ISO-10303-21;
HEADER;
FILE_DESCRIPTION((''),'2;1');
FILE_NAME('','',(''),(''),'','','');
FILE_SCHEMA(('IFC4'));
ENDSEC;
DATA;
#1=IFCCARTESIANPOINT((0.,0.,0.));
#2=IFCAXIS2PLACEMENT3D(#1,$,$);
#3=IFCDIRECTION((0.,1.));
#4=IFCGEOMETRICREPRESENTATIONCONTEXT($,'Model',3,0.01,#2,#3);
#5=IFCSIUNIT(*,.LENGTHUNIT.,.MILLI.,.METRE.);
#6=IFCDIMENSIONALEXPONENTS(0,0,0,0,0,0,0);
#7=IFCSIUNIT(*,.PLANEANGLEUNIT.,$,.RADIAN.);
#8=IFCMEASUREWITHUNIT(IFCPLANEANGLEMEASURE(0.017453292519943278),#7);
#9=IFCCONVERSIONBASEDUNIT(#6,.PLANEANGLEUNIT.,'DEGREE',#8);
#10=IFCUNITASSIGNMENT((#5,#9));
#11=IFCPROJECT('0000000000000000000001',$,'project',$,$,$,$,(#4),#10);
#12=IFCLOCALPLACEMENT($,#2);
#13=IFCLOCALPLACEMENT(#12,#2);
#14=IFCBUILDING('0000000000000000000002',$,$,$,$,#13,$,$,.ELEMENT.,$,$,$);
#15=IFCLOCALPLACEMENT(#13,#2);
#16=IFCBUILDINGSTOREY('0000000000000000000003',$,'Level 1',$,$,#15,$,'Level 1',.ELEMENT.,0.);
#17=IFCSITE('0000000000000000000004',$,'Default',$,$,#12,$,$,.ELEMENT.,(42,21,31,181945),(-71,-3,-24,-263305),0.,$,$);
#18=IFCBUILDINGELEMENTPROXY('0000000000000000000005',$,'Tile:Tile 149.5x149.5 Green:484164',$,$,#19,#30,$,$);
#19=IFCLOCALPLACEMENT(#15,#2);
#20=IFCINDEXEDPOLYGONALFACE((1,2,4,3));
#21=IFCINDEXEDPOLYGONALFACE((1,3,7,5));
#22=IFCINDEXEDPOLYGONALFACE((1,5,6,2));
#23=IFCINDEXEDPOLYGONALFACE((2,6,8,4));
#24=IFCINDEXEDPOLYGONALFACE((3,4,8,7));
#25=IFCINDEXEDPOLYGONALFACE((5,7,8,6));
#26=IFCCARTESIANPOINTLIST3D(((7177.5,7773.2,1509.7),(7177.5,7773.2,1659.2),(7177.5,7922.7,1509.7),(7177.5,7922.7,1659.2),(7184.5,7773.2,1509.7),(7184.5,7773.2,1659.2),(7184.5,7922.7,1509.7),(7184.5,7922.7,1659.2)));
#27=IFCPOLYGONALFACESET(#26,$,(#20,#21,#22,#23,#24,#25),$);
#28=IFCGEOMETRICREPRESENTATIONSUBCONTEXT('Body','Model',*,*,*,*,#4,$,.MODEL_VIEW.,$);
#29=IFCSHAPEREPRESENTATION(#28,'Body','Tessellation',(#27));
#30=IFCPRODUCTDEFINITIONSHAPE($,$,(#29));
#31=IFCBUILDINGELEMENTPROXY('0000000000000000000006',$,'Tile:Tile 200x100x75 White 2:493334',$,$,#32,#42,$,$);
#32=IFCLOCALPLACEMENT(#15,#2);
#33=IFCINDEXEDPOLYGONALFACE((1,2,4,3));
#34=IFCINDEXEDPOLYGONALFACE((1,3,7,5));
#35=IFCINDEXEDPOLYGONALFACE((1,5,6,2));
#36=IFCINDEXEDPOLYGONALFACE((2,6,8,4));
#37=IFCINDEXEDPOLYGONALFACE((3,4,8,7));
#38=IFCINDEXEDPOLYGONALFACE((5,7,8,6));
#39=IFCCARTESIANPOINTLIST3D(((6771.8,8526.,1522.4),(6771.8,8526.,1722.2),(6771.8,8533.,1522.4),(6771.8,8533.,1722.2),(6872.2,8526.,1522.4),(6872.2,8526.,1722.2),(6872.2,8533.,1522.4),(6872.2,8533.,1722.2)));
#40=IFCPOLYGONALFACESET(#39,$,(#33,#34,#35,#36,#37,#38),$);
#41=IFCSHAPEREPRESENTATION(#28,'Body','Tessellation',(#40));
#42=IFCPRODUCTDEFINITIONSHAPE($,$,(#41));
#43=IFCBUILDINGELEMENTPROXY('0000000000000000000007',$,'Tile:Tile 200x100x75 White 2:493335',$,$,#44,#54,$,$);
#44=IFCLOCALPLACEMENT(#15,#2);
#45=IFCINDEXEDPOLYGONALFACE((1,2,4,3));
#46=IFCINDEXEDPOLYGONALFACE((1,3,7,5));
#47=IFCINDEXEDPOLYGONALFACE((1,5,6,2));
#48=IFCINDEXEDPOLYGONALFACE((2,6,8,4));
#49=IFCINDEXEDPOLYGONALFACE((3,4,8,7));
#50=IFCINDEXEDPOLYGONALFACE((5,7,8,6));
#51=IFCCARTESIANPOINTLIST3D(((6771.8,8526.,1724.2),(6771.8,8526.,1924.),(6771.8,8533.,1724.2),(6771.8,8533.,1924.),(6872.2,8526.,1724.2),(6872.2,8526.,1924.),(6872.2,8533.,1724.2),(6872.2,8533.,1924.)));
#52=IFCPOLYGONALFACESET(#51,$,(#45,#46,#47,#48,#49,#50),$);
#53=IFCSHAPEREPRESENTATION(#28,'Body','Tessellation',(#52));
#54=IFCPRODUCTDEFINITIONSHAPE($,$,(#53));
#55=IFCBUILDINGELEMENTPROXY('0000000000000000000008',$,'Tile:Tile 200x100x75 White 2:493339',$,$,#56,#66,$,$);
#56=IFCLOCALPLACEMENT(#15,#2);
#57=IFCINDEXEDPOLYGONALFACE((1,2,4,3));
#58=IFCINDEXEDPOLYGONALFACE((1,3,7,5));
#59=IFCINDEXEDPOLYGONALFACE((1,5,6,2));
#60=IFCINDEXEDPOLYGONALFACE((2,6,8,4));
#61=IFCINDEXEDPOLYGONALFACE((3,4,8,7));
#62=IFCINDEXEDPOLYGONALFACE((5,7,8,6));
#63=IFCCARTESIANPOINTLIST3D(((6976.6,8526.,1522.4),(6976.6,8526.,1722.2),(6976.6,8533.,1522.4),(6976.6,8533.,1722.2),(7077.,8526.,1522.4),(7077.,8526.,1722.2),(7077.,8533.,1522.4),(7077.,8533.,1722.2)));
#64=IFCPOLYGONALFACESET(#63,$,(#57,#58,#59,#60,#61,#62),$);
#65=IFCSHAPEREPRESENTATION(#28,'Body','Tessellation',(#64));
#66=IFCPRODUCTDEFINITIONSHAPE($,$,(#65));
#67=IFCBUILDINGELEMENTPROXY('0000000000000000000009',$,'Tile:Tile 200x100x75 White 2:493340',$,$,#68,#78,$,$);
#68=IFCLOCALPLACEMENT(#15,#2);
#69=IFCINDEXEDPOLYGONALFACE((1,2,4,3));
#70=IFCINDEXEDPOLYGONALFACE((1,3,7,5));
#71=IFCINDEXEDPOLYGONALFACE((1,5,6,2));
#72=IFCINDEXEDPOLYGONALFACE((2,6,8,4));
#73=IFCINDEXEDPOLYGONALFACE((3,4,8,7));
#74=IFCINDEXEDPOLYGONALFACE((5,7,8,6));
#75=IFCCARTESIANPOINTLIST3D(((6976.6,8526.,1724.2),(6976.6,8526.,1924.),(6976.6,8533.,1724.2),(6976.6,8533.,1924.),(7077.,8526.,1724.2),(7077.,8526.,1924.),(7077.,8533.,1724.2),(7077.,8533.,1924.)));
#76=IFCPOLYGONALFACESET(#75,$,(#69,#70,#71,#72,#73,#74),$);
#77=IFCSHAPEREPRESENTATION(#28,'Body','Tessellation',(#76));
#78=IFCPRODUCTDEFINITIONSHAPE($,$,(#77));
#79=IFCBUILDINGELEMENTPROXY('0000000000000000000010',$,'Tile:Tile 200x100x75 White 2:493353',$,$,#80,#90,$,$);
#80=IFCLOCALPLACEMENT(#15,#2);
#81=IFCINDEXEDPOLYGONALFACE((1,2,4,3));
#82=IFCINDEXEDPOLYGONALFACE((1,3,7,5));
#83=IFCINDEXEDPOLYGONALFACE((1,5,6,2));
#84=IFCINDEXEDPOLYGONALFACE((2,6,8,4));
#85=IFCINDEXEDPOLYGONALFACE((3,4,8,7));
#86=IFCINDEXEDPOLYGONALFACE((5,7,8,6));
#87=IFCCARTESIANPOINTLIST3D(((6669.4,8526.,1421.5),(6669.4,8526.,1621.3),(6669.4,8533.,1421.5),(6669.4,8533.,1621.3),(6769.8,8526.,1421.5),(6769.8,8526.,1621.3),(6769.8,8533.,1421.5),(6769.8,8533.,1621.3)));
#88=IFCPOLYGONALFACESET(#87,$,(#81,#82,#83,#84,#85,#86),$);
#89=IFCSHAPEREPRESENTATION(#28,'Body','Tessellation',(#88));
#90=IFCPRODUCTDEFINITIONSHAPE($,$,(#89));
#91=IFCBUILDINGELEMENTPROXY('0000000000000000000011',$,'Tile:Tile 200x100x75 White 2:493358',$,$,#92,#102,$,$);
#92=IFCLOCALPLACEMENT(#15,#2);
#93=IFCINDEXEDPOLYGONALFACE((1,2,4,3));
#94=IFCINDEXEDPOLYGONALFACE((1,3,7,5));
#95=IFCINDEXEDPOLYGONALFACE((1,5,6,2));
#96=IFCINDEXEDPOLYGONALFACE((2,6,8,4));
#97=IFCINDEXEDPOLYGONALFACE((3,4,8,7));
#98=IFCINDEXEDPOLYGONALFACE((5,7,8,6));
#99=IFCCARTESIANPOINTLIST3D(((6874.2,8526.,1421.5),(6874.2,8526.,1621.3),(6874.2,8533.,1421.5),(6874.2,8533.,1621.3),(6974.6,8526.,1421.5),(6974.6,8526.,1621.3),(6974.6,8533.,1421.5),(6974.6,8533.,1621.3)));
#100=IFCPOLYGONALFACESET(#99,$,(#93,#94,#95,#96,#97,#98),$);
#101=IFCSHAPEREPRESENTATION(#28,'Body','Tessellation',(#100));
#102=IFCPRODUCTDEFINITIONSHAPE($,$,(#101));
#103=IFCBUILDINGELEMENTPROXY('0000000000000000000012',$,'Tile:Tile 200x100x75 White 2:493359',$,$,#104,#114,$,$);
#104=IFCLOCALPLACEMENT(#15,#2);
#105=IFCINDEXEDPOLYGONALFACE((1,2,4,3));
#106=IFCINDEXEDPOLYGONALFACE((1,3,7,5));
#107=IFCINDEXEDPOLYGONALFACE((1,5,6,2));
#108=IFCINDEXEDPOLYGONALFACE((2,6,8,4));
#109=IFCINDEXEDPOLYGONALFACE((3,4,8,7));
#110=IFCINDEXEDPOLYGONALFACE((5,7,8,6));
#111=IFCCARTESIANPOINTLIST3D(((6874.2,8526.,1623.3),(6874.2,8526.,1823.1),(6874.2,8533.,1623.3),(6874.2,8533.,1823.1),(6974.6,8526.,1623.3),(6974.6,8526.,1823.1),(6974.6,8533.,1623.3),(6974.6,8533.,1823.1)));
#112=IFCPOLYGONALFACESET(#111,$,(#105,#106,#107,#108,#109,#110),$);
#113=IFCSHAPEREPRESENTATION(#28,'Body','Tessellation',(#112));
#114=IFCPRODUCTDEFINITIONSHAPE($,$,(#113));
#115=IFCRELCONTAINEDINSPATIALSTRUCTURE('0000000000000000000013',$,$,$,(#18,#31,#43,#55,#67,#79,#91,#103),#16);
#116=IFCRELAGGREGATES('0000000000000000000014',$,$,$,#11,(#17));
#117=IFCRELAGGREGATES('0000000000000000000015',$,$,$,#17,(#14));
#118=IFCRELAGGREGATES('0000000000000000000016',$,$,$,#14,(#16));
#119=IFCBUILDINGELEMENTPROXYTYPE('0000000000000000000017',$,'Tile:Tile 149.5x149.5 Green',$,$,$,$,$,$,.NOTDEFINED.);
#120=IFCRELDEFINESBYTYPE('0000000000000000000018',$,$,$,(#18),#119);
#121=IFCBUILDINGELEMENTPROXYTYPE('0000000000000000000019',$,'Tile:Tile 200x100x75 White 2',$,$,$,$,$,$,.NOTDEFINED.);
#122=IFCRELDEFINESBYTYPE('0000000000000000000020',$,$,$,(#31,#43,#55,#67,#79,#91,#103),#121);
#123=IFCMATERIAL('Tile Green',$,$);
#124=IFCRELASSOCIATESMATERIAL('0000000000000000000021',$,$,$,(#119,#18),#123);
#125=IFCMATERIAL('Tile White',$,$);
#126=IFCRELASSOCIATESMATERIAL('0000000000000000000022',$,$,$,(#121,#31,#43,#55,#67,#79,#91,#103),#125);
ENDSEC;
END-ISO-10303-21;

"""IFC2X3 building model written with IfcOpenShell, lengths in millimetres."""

from ifc_helpers import new_model, entity, si_unit, converted_unit, direction, frame, frame_2d, origin, origin_2d_with_axis, place, context, subcontext, project, spatial, rectangle, extrude, source, transform, mapped, material, type_object, type_shapes, element, save


model = new_model("IFC2X3")

# Units and contexts
model_context = context("Model", 3, precision=0.01, world=origin(), true_north=direction((0.0, 1.0)))
body_context = subcontext(model_context, "Body", "Model", "MODEL_VIEW")
ifc_project = project(units=[si_unit("LENGTHUNIT", "METRE", prefix="MILLI"), converted_unit("PLANEANGLEUNIT", "DEGREE", entity("IfcPlaneAngleMeasure", 0.017453292519943278), si_unit("PLANEANGLEUNIT", "RADIAN"), dimensions=[0, 0, 0, 0, 0, 0, 0])], contexts=[model_context])

# Site, building, storey
site_placement = place(None, origin())
site = spatial("IfcSite", under=ifc_project, at=site_placement, Name="Default", CompositionType="ELEMENT", RefLatitude=(42, 21, 31, 181945), RefLongitude=(-71, -3, -24, -263305), RefElevation=0.0)
building_placement = place(site_placement, origin())
building = spatial("IfcBuilding", under=site, at=building_placement, CompositionType="ELEMENT")
storey_placement = place(building_placement, origin())
storey = spatial("IfcBuildingStorey", under=building, at=storey_placement, Name="Level 1", LongName="Level 1", CompositionType="ELEMENT", Elevation=0.0)

# Building element proxies
ifc_material_1 = material(Name="Tile White")
ifc_material_2 = material(Name="Tile Green")
building_element_proxy_type_1 = type_object("IfcBuildingElementProxyType", Name="Tile:Tile 149.5x149.5 Green", PredefinedType="NOTDEFINED", material=ifc_material_2)
shared_shape_1 = source(origin(), body_context, "Body", "SweptSolid", [
    extrude(rectangle(XDim=149.5, YDim=149.5, at=origin_2d_with_axis()), frame((-74.7, -74.8, 0.0), z_axis=(0.0, 0.0, 1.0), x_axis=(0.0, -1.0, 0.0)), (0.0, 0.0, 1.0), 7.0),
])
type_shapes(building_element_proxy_type_1, [shared_shape_1])
proxy_1_placement = place(storey_placement, frame((7184.5, 7922.7, 1659.2), z_axis=(-1.0, 0.0, 0.0), x_axis=(0.0, 0.0, 1.0)))
element("IfcBuildingElementProxy", 1, at=proxy_1_placement, inside=storey, type_object=building_element_proxy_type_1, material=ifc_material_2, Name="Tile:Tile 149.5x149.5 Green:484164", context=body_context, shape_type="MappedRepresentation", body=[
    mapped(shared_shape_1, transform((0.0, 0.0, 0.0), scale=1.0)),
])
building_element_proxy_type_2 = type_object("IfcBuildingElementProxyType", Name="Tile:Tile 200x100x75 White 2", PredefinedType="NOTDEFINED", material=ifc_material_1)
shared_shape_2 = source(origin(), body_context, "Body", "SweptSolid", [
    extrude(rectangle(XDim=199.8, YDim=100.4, at=frame_2d((0.0, 0.0), x_axis=(1.0, 0.0))), frame((-50.2, -99.9, 0.0), z_axis=(0.0, 0.0, 1.0), x_axis=(0.0, -1.0, 0.0)), (0.0, 0.0, 1.0), 7.0),
])
type_shapes(building_element_proxy_type_2, [shared_shape_2])
for number, where, z_axis, x_axis, name in (
    (2, (6872.2, 8533.0, 1722.2), (0.0, -1.0, 0.0), (1.0, 0.0, 0.0), "Tile:Tile 200x100x75 White 2:493334"),
    (3, (6872.2, 8533.0, 1924.0), (0.0, -1.0, 0.0), (1.0, 0.0, 0.0), "Tile:Tile 200x100x75 White 2:493335"),
    (4, (7077.0, 8533.0, 1722.2), (0.0, -1.0, 0.0), (1.0, 0.0, 0.0), "Tile:Tile 200x100x75 White 2:493339"),
    (5, (7077.0, 8533.0, 1924.0), (0.0, -1.0, 0.0), (1.0, 0.0, 0.0), "Tile:Tile 200x100x75 White 2:493340"),
    (6, (6769.8, 8533.0, 1621.3), (0.0, -1.0, 0.0), (1.0, 0.0, 0.0), "Tile:Tile 200x100x75 White 2:493353"),
    (7, (6974.6, 8533.0, 1621.3), (0.0, -1.0, 0.0), (1.0, 0.0, 0.0), "Tile:Tile 200x100x75 White 2:493358"),
    (8, (6974.6, 8533.0, 1823.1), (0.0, -1.0, 0.0), (1.0, 0.0, 0.0), "Tile:Tile 200x100x75 White 2:493359"),
):
    element("IfcBuildingElementProxy", number, at=place(storey_placement, frame(where, z_axis=z_axis, x_axis=x_axis)), inside=storey, type_object=building_element_proxy_type_2, material=ifc_material_1, Name=name, context=body_context, shape_type="MappedRepresentation", body=[
        mapped(shared_shape_2, transform((0.0, 0.0, 0.0), scale=1.0)),
    ])

save(model, "model.ifc")
